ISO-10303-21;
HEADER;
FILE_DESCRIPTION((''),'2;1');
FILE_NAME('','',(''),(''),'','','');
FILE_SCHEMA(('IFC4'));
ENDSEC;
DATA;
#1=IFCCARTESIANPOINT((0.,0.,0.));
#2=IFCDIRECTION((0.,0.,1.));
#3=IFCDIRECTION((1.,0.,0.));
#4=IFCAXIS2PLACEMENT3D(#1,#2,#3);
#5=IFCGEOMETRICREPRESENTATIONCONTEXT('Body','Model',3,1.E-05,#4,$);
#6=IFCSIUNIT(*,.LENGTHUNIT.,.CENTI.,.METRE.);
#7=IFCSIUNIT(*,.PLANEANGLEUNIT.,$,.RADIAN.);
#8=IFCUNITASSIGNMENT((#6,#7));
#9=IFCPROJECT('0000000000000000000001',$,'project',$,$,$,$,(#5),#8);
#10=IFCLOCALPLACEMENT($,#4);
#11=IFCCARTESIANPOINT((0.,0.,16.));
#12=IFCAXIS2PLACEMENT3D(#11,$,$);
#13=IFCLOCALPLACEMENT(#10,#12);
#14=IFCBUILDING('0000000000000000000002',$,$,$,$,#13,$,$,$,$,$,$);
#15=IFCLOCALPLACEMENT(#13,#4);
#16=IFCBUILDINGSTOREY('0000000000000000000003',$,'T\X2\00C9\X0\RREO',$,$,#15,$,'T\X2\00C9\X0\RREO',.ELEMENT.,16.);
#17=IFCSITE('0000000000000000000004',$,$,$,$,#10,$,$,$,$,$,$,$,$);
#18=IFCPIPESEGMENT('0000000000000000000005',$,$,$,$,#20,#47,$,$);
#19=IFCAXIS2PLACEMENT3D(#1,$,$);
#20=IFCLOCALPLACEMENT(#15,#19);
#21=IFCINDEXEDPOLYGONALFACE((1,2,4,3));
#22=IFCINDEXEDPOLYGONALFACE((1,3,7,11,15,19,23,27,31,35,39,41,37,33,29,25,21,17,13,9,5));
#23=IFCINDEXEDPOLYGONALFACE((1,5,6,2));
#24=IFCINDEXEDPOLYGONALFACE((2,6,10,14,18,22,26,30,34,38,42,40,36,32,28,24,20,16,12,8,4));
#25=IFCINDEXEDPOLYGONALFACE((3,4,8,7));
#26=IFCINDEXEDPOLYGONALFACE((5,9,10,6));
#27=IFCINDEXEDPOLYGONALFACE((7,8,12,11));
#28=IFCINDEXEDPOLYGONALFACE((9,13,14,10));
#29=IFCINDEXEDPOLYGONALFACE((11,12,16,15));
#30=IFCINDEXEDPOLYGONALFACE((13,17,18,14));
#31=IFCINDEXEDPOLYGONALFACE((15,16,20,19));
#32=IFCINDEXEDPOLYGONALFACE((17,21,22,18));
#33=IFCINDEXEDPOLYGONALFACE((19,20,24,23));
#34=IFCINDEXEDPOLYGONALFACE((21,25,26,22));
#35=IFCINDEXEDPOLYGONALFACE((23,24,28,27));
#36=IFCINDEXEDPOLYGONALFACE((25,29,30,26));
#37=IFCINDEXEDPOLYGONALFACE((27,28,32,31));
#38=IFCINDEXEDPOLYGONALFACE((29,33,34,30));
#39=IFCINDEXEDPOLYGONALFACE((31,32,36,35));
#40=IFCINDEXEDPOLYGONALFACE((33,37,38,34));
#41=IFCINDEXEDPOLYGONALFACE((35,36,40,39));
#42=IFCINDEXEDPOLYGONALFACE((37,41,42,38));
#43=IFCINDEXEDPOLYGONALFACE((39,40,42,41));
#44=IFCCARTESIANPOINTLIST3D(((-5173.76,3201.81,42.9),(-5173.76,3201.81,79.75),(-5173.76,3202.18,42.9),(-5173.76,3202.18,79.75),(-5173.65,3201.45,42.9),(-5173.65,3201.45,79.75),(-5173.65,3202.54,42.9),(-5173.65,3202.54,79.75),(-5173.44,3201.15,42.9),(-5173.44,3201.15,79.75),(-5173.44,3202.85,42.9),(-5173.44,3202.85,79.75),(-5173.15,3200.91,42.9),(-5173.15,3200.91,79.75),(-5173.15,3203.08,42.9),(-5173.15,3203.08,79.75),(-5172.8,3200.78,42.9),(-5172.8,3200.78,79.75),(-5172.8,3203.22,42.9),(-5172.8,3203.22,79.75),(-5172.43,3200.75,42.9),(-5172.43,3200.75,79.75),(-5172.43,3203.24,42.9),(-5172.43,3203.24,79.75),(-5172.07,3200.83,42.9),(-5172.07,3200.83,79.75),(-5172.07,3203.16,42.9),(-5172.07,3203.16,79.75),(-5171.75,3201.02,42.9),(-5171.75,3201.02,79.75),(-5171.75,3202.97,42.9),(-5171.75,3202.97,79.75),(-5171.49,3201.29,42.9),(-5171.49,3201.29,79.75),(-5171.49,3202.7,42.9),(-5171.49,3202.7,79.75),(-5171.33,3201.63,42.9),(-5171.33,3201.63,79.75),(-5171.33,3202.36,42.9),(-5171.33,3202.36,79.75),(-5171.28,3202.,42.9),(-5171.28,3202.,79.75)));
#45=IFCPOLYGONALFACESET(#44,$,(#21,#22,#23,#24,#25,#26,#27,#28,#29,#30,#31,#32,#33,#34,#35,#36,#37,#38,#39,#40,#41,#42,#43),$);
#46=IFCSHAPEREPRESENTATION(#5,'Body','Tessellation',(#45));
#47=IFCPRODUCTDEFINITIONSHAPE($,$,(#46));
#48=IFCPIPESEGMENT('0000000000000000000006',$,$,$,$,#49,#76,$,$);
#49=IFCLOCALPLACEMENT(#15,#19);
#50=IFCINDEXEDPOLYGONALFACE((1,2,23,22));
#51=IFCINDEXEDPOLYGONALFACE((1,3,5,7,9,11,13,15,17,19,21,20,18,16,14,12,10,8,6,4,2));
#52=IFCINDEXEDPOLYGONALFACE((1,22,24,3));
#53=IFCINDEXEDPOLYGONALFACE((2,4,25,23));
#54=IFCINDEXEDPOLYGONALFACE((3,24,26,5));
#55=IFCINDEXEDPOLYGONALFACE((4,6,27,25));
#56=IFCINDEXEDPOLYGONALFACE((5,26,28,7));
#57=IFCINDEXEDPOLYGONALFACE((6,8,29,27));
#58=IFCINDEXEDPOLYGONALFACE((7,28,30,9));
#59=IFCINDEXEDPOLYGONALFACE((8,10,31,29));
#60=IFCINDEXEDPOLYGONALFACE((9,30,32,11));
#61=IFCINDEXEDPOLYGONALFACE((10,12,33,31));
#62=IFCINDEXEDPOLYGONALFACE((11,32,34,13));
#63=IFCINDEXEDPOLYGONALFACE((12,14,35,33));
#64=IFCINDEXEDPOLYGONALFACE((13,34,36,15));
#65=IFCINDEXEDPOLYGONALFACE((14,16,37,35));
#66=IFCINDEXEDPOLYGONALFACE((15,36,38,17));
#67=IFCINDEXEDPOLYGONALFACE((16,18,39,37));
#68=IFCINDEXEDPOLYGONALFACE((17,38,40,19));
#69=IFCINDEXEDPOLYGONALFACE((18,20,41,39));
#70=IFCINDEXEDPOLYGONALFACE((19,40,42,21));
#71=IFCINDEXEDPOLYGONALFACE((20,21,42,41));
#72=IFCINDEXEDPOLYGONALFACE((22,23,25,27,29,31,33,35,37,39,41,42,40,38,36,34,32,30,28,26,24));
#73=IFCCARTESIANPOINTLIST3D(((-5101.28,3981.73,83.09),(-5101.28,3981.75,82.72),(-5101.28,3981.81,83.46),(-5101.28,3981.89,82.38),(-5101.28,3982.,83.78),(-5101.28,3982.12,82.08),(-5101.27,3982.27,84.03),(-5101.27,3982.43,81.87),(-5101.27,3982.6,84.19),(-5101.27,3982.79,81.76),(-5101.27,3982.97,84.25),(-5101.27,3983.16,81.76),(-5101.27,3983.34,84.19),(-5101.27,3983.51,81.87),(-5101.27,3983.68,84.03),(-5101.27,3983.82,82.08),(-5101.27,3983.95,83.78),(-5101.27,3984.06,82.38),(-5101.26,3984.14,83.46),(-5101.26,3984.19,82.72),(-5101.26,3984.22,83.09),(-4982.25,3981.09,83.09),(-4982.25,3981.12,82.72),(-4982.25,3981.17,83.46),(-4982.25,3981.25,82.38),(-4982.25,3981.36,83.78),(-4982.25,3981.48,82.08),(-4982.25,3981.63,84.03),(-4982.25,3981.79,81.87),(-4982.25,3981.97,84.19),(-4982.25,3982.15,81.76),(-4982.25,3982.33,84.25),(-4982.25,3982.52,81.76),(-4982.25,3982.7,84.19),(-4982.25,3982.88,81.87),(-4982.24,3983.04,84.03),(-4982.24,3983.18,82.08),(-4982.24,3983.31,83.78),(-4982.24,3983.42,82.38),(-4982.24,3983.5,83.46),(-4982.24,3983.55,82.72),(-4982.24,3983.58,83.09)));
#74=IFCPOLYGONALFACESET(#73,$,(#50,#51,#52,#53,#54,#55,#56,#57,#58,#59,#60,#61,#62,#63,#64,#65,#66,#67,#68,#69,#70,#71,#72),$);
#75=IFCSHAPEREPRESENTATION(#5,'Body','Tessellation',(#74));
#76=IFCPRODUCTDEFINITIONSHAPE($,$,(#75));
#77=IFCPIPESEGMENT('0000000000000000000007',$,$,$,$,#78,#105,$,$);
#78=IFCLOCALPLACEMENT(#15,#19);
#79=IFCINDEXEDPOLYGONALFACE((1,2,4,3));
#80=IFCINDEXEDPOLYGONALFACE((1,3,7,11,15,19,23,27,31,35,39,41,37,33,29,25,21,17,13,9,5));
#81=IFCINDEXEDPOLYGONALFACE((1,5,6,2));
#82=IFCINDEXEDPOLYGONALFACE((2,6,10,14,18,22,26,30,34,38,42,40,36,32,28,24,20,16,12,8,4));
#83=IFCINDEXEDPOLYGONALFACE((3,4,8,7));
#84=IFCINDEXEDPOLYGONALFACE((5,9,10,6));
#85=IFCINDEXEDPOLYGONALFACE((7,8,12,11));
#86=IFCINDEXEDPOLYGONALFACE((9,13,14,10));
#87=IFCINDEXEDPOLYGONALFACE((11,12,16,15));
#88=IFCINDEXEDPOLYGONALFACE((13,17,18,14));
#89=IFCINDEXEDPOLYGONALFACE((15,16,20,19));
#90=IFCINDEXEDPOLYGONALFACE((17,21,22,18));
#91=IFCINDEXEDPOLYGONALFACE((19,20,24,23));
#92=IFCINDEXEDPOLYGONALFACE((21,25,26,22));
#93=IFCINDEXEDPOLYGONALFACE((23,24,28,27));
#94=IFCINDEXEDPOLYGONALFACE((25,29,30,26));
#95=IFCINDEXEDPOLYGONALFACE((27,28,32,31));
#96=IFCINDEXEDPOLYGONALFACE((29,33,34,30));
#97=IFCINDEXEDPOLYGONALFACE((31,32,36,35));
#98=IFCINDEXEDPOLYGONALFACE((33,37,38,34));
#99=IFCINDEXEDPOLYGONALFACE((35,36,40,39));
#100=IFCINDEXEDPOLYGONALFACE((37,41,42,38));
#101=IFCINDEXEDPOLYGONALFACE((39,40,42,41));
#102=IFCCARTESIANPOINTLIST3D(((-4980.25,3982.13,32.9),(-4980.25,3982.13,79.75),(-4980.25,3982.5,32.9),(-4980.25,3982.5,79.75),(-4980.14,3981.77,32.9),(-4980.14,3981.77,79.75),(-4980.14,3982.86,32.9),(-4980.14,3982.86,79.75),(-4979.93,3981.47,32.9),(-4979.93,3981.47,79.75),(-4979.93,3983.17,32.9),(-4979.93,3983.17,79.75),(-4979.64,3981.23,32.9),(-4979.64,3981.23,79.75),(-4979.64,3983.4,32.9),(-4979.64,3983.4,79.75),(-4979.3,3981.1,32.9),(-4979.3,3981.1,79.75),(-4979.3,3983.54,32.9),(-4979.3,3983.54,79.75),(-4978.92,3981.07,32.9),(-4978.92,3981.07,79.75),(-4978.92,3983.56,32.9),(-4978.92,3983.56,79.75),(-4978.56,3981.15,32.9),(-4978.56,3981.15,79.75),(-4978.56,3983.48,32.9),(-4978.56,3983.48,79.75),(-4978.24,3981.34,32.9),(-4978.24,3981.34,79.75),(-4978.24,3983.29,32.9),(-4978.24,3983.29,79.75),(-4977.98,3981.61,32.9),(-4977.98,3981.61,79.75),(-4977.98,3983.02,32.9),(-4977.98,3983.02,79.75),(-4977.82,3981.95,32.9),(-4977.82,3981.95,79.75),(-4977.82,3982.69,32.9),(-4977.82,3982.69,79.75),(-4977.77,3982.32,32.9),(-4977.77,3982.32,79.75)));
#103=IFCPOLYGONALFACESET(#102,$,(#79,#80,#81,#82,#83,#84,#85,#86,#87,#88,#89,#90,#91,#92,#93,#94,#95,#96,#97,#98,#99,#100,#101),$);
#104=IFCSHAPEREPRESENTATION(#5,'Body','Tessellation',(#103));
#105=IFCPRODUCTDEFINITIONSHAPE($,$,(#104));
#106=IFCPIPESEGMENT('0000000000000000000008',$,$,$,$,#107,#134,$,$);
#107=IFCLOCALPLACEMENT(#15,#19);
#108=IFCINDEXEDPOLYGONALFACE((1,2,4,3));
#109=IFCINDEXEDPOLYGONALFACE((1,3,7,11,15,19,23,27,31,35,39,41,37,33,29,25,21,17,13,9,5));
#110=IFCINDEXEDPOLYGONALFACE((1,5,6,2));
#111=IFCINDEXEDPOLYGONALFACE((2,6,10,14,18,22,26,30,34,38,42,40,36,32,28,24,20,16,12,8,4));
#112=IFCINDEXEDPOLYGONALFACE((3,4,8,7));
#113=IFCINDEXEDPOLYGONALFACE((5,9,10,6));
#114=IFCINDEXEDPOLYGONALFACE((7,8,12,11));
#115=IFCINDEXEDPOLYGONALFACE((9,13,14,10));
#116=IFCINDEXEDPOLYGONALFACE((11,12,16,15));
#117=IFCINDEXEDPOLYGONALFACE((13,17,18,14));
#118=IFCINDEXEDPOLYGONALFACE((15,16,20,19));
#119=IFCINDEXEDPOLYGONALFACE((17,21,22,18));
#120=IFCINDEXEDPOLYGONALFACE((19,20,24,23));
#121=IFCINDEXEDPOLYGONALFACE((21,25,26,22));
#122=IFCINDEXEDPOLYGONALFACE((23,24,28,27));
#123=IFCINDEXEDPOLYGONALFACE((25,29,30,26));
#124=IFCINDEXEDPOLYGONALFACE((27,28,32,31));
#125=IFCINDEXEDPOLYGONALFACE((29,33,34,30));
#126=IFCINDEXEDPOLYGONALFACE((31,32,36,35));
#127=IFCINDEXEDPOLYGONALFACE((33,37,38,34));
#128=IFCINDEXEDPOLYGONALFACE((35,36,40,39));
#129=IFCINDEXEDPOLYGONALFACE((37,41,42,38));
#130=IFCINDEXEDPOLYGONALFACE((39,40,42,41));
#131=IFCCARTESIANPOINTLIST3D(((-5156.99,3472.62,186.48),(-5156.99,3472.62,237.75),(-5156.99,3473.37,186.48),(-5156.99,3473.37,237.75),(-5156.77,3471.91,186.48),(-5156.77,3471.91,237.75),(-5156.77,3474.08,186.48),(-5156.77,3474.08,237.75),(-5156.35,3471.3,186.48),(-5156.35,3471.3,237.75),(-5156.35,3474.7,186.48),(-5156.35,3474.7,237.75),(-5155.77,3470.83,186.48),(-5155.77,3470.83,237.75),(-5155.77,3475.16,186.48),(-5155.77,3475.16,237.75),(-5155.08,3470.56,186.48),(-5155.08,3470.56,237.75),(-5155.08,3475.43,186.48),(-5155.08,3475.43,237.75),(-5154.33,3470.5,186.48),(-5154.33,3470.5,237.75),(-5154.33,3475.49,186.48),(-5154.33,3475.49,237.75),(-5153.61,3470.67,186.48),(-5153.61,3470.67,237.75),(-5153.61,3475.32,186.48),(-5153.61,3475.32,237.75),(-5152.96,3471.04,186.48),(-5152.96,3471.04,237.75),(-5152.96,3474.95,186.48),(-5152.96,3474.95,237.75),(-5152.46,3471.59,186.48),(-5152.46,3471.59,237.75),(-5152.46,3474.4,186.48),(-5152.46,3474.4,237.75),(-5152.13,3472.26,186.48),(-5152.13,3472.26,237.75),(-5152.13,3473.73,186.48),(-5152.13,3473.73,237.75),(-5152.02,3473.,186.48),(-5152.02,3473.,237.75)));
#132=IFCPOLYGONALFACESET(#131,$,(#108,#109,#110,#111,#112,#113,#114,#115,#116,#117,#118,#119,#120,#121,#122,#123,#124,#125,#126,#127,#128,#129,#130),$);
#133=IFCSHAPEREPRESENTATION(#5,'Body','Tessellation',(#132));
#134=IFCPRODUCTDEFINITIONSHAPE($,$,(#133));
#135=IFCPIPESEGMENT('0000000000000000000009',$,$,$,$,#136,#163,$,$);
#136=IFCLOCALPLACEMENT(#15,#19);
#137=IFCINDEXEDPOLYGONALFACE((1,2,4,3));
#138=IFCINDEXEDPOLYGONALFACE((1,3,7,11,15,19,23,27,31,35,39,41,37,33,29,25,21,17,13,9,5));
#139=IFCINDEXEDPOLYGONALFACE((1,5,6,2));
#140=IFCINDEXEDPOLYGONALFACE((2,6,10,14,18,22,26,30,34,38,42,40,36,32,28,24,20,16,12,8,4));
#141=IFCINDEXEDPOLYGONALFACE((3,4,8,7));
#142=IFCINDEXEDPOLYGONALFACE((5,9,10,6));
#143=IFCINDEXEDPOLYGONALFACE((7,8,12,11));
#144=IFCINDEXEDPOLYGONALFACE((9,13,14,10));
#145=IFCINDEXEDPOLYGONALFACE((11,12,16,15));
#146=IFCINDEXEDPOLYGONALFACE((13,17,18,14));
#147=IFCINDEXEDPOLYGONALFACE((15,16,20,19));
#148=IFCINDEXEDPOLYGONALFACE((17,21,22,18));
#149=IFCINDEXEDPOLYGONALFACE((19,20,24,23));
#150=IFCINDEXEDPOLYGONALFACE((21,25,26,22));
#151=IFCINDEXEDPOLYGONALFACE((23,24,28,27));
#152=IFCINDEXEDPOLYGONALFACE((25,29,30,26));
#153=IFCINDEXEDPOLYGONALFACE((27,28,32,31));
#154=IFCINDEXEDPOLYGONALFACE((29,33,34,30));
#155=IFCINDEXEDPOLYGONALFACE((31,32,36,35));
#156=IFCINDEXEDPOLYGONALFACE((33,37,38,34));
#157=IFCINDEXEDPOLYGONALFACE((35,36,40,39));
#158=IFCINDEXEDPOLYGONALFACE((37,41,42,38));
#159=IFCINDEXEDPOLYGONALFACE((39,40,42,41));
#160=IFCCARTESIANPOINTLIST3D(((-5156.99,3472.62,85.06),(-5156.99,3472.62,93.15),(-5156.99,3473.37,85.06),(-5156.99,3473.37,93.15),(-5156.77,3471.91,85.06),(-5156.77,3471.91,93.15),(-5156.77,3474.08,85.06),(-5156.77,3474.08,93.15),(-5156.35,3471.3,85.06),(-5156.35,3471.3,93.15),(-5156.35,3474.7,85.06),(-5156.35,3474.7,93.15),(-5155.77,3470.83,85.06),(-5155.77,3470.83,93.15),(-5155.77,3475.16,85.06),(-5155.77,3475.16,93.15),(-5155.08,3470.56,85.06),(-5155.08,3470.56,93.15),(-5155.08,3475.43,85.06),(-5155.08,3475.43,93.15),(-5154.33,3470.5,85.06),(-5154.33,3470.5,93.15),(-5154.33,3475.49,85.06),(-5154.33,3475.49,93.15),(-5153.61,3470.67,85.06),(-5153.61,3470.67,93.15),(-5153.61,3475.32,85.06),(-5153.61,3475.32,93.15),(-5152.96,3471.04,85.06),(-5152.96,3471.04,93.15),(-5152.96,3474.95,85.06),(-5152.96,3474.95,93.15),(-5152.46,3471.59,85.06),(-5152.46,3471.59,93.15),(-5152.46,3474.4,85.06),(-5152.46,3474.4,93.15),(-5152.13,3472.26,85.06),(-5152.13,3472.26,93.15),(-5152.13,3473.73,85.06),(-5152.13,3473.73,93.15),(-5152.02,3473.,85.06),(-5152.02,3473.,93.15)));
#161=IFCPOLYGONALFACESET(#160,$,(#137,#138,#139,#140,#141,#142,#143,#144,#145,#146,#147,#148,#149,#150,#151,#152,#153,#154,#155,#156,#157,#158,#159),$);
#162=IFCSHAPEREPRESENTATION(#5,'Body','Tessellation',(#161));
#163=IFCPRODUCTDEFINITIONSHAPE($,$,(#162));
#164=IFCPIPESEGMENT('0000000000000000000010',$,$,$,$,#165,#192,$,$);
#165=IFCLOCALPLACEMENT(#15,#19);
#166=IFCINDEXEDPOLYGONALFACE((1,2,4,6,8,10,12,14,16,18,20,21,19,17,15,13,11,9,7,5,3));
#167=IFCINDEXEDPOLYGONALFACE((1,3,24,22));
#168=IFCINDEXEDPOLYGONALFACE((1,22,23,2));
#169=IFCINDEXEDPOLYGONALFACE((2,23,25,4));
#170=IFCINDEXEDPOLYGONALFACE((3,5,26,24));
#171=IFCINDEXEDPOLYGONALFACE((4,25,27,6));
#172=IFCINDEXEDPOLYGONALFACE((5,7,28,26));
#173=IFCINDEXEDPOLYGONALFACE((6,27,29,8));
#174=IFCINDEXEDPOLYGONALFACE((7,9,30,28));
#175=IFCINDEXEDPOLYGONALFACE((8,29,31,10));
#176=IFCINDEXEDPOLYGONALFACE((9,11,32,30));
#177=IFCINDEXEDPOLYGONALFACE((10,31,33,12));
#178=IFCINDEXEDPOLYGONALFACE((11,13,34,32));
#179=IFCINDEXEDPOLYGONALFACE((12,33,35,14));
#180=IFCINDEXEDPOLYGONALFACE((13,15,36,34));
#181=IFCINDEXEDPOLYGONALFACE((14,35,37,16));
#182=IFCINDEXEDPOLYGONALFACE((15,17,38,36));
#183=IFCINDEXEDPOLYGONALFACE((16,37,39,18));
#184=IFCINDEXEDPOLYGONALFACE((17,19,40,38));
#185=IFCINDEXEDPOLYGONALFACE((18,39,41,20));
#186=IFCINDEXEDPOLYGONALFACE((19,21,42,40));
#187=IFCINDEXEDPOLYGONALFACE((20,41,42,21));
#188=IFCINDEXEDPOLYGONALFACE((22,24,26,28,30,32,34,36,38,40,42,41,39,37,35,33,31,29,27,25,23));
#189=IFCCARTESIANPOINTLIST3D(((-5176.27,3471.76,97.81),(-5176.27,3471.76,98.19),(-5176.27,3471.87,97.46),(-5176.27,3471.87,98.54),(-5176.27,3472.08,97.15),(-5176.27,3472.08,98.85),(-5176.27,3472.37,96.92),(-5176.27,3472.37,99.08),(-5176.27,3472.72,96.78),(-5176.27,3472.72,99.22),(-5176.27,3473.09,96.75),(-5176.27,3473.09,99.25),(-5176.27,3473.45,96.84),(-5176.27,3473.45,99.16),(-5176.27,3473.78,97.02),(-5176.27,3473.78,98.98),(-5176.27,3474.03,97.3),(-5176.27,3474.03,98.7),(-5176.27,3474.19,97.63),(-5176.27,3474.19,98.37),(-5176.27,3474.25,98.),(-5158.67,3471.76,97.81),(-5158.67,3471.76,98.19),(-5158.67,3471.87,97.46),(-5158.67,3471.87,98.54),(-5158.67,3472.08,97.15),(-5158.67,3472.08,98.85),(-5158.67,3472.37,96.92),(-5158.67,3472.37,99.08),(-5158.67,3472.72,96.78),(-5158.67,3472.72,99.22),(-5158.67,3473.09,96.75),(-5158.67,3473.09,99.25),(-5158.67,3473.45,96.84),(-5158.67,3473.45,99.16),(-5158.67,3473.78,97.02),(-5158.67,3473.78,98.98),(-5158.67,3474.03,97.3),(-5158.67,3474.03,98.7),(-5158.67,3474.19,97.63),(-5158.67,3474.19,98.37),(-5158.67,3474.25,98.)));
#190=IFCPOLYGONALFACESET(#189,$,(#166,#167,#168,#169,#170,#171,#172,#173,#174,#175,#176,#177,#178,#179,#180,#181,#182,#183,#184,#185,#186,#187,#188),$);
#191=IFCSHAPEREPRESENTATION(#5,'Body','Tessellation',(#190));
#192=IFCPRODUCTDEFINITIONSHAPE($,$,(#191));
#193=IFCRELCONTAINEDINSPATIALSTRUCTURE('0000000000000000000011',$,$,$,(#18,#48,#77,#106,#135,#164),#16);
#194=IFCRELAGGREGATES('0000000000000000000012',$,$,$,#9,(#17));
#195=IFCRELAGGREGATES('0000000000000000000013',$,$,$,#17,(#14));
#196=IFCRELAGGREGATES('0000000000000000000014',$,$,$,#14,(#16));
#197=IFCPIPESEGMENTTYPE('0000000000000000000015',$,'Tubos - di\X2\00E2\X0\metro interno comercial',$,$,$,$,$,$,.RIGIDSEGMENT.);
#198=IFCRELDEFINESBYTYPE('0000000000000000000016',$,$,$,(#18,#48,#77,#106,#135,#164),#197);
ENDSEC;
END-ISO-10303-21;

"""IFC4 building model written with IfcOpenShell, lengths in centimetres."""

from ifc_helpers import new_model, si_unit, frame, origin_with_axes, origin_2d_with_axis, place, context, project, spatial, circle, extrude, type_object, element, save


model = new_model("IFC4")

# Units and contexts
model_context = context("Model", 3, precision=1e-05, world=origin_with_axes(), identifier="Body")
ifc_project = project(units=[si_unit("LENGTHUNIT", "METRE", prefix="CENTI"), si_unit("PLANEANGLEUNIT", "RADIAN")], contexts=[model_context])

# Site, building, storey
site_placement = place(None, origin_with_axes())
site = spatial("IfcSite", under=ifc_project, at=site_placement)
building_placement = place(site_placement, frame((0.0, 0.0, 16.0)))
building = spatial("IfcBuilding", under=site, at=building_placement)
storey_placement = place(building_placement, origin_with_axes())
storey = spatial("IfcBuildingStorey", under=building, at=storey_placement, Name="TÉRREO", LongName="TÉRREO", CompositionType="ELEMENT", Elevation=16.0)

# Pipe segments
pipe_segment_type = type_object("IfcPipeSegmentType", Name="Tubos - diâmetro interno comercial", PredefinedType="RIGIDSEGMENT")
for number, where, z_axis, x_axis in (
    (1, (-5172.53, 3202.0, 79.75), (0.0, 0.0, 1.0), (1.0, 0.0, 0.0)),
):
    element("IfcPipeSegment", number, at=place(storey_placement, frame(where, z_axis=z_axis, x_axis=x_axis)), inside=storey, type_object=pipe_segment_type, context=model_context, shape_type="SolidModel", body=[
        extrude(circle(Radius=1.25, at=origin_2d_with_axis()), frame((0.0, 0.0, 0.0), z_axis=(0.0, 0.0, -1.0), x_axis=(1.0, 0.0, 0.0)), (0.0, 0.0, 1.0), 36.85),
    ])
pipe_segment_1_placement = place(storey_placement, frame((-5041.76, 3982.65, 84.25), z_axis=(0.0, 0.0, 1.0), x_axis=(1.0, 0.0, 0.0)))
element("IfcPipeSegment", 2, at=pipe_segment_1_placement, inside=storey, type_object=pipe_segment_type, context=model_context, shape_type="SolidModel", body=[
    extrude(circle(Radius=1.25, at=origin_2d_with_axis()), frame((59.51, -0.32, -1.25), z_axis=(-1.0, 0.005363, 0.0), x_axis=(0.0, 0.0, 1.0)), (0.0, 0.0, 1.0), 119.02),
])
pipe_segment_2_placement = place(storey_placement, frame((-4979.02, 3982.32, 79.75), z_axis=(0.0, 0.0, 1.0), x_axis=(1.0, 0.0, 0.0)))
element("IfcPipeSegment", 3, at=pipe_segment_2_placement, inside=storey, type_object=pipe_segment_type, context=model_context, shape_type="SolidModel", body=[
    extrude(circle(Radius=1.25, at=origin_2d_with_axis()), frame((0.0, 0.0, 0.0), z_axis=(0.0, 0.0, -1.0), x_axis=(1.0, 0.0, 0.0)), (0.0, 0.0, 1.0), 46.85),
])
pipe_segment_3_placement = place(storey_placement, frame((-5154.52, 3473.0, 237.75), z_axis=(0.0, 0.0, 1.0), x_axis=(1.0, 0.0, 0.0)))
element("IfcPipeSegment", 4, at=pipe_segment_3_placement, inside=storey, type_object=pipe_segment_type, context=model_context, shape_type="SolidModel", body=[
    extrude(circle(Radius=2.5, at=origin_2d_with_axis()), frame((0.0, 0.0, 0.0), z_axis=(0.0, 0.0, -1.0), x_axis=(1.0, 0.0, 0.0)), (0.0, 0.0, 1.0), 51.27),
])
pipe_segment_4_placement = place(storey_placement, frame((-5154.52, 3473.0, 93.15), z_axis=(0.0, 0.0, 1.0), x_axis=(1.0, 0.0, 0.0)))
element("IfcPipeSegment", 5, at=pipe_segment_4_placement, inside=storey, type_object=pipe_segment_type, context=model_context, shape_type="SolidModel", body=[
    extrude(circle(Radius=2.5, at=origin_2d_with_axis()), frame((0.0, 0.0, 0.0), z_axis=(0.0, 0.0, -1.0), x_axis=(1.0, 0.0, 0.0)), (0.0, 0.0, 1.0), 8.09),
])
pipe_segment_5_placement = place(storey_placement, frame((-5167.47, 3473.0, 99.25), z_axis=(0.0, 0.0, 1.0), x_axis=(1.0, 0.0, 0.0)))
element("IfcPipeSegment", 6, at=pipe_segment_5_placement, inside=storey, type_object=pipe_segment_type, context=model_context, shape_type="SolidModel", body=[
    extrude(circle(Radius=1.25, at=origin_2d_with_axis()), frame((8.8, 0.0, -1.25), z_axis=(-1.0, 0.0, 0.0), x_axis=(0.0, 1.0, 0.0)), (0.0, 0.0, 1.0), 17.6),
])

save(model, "model.ifc")
